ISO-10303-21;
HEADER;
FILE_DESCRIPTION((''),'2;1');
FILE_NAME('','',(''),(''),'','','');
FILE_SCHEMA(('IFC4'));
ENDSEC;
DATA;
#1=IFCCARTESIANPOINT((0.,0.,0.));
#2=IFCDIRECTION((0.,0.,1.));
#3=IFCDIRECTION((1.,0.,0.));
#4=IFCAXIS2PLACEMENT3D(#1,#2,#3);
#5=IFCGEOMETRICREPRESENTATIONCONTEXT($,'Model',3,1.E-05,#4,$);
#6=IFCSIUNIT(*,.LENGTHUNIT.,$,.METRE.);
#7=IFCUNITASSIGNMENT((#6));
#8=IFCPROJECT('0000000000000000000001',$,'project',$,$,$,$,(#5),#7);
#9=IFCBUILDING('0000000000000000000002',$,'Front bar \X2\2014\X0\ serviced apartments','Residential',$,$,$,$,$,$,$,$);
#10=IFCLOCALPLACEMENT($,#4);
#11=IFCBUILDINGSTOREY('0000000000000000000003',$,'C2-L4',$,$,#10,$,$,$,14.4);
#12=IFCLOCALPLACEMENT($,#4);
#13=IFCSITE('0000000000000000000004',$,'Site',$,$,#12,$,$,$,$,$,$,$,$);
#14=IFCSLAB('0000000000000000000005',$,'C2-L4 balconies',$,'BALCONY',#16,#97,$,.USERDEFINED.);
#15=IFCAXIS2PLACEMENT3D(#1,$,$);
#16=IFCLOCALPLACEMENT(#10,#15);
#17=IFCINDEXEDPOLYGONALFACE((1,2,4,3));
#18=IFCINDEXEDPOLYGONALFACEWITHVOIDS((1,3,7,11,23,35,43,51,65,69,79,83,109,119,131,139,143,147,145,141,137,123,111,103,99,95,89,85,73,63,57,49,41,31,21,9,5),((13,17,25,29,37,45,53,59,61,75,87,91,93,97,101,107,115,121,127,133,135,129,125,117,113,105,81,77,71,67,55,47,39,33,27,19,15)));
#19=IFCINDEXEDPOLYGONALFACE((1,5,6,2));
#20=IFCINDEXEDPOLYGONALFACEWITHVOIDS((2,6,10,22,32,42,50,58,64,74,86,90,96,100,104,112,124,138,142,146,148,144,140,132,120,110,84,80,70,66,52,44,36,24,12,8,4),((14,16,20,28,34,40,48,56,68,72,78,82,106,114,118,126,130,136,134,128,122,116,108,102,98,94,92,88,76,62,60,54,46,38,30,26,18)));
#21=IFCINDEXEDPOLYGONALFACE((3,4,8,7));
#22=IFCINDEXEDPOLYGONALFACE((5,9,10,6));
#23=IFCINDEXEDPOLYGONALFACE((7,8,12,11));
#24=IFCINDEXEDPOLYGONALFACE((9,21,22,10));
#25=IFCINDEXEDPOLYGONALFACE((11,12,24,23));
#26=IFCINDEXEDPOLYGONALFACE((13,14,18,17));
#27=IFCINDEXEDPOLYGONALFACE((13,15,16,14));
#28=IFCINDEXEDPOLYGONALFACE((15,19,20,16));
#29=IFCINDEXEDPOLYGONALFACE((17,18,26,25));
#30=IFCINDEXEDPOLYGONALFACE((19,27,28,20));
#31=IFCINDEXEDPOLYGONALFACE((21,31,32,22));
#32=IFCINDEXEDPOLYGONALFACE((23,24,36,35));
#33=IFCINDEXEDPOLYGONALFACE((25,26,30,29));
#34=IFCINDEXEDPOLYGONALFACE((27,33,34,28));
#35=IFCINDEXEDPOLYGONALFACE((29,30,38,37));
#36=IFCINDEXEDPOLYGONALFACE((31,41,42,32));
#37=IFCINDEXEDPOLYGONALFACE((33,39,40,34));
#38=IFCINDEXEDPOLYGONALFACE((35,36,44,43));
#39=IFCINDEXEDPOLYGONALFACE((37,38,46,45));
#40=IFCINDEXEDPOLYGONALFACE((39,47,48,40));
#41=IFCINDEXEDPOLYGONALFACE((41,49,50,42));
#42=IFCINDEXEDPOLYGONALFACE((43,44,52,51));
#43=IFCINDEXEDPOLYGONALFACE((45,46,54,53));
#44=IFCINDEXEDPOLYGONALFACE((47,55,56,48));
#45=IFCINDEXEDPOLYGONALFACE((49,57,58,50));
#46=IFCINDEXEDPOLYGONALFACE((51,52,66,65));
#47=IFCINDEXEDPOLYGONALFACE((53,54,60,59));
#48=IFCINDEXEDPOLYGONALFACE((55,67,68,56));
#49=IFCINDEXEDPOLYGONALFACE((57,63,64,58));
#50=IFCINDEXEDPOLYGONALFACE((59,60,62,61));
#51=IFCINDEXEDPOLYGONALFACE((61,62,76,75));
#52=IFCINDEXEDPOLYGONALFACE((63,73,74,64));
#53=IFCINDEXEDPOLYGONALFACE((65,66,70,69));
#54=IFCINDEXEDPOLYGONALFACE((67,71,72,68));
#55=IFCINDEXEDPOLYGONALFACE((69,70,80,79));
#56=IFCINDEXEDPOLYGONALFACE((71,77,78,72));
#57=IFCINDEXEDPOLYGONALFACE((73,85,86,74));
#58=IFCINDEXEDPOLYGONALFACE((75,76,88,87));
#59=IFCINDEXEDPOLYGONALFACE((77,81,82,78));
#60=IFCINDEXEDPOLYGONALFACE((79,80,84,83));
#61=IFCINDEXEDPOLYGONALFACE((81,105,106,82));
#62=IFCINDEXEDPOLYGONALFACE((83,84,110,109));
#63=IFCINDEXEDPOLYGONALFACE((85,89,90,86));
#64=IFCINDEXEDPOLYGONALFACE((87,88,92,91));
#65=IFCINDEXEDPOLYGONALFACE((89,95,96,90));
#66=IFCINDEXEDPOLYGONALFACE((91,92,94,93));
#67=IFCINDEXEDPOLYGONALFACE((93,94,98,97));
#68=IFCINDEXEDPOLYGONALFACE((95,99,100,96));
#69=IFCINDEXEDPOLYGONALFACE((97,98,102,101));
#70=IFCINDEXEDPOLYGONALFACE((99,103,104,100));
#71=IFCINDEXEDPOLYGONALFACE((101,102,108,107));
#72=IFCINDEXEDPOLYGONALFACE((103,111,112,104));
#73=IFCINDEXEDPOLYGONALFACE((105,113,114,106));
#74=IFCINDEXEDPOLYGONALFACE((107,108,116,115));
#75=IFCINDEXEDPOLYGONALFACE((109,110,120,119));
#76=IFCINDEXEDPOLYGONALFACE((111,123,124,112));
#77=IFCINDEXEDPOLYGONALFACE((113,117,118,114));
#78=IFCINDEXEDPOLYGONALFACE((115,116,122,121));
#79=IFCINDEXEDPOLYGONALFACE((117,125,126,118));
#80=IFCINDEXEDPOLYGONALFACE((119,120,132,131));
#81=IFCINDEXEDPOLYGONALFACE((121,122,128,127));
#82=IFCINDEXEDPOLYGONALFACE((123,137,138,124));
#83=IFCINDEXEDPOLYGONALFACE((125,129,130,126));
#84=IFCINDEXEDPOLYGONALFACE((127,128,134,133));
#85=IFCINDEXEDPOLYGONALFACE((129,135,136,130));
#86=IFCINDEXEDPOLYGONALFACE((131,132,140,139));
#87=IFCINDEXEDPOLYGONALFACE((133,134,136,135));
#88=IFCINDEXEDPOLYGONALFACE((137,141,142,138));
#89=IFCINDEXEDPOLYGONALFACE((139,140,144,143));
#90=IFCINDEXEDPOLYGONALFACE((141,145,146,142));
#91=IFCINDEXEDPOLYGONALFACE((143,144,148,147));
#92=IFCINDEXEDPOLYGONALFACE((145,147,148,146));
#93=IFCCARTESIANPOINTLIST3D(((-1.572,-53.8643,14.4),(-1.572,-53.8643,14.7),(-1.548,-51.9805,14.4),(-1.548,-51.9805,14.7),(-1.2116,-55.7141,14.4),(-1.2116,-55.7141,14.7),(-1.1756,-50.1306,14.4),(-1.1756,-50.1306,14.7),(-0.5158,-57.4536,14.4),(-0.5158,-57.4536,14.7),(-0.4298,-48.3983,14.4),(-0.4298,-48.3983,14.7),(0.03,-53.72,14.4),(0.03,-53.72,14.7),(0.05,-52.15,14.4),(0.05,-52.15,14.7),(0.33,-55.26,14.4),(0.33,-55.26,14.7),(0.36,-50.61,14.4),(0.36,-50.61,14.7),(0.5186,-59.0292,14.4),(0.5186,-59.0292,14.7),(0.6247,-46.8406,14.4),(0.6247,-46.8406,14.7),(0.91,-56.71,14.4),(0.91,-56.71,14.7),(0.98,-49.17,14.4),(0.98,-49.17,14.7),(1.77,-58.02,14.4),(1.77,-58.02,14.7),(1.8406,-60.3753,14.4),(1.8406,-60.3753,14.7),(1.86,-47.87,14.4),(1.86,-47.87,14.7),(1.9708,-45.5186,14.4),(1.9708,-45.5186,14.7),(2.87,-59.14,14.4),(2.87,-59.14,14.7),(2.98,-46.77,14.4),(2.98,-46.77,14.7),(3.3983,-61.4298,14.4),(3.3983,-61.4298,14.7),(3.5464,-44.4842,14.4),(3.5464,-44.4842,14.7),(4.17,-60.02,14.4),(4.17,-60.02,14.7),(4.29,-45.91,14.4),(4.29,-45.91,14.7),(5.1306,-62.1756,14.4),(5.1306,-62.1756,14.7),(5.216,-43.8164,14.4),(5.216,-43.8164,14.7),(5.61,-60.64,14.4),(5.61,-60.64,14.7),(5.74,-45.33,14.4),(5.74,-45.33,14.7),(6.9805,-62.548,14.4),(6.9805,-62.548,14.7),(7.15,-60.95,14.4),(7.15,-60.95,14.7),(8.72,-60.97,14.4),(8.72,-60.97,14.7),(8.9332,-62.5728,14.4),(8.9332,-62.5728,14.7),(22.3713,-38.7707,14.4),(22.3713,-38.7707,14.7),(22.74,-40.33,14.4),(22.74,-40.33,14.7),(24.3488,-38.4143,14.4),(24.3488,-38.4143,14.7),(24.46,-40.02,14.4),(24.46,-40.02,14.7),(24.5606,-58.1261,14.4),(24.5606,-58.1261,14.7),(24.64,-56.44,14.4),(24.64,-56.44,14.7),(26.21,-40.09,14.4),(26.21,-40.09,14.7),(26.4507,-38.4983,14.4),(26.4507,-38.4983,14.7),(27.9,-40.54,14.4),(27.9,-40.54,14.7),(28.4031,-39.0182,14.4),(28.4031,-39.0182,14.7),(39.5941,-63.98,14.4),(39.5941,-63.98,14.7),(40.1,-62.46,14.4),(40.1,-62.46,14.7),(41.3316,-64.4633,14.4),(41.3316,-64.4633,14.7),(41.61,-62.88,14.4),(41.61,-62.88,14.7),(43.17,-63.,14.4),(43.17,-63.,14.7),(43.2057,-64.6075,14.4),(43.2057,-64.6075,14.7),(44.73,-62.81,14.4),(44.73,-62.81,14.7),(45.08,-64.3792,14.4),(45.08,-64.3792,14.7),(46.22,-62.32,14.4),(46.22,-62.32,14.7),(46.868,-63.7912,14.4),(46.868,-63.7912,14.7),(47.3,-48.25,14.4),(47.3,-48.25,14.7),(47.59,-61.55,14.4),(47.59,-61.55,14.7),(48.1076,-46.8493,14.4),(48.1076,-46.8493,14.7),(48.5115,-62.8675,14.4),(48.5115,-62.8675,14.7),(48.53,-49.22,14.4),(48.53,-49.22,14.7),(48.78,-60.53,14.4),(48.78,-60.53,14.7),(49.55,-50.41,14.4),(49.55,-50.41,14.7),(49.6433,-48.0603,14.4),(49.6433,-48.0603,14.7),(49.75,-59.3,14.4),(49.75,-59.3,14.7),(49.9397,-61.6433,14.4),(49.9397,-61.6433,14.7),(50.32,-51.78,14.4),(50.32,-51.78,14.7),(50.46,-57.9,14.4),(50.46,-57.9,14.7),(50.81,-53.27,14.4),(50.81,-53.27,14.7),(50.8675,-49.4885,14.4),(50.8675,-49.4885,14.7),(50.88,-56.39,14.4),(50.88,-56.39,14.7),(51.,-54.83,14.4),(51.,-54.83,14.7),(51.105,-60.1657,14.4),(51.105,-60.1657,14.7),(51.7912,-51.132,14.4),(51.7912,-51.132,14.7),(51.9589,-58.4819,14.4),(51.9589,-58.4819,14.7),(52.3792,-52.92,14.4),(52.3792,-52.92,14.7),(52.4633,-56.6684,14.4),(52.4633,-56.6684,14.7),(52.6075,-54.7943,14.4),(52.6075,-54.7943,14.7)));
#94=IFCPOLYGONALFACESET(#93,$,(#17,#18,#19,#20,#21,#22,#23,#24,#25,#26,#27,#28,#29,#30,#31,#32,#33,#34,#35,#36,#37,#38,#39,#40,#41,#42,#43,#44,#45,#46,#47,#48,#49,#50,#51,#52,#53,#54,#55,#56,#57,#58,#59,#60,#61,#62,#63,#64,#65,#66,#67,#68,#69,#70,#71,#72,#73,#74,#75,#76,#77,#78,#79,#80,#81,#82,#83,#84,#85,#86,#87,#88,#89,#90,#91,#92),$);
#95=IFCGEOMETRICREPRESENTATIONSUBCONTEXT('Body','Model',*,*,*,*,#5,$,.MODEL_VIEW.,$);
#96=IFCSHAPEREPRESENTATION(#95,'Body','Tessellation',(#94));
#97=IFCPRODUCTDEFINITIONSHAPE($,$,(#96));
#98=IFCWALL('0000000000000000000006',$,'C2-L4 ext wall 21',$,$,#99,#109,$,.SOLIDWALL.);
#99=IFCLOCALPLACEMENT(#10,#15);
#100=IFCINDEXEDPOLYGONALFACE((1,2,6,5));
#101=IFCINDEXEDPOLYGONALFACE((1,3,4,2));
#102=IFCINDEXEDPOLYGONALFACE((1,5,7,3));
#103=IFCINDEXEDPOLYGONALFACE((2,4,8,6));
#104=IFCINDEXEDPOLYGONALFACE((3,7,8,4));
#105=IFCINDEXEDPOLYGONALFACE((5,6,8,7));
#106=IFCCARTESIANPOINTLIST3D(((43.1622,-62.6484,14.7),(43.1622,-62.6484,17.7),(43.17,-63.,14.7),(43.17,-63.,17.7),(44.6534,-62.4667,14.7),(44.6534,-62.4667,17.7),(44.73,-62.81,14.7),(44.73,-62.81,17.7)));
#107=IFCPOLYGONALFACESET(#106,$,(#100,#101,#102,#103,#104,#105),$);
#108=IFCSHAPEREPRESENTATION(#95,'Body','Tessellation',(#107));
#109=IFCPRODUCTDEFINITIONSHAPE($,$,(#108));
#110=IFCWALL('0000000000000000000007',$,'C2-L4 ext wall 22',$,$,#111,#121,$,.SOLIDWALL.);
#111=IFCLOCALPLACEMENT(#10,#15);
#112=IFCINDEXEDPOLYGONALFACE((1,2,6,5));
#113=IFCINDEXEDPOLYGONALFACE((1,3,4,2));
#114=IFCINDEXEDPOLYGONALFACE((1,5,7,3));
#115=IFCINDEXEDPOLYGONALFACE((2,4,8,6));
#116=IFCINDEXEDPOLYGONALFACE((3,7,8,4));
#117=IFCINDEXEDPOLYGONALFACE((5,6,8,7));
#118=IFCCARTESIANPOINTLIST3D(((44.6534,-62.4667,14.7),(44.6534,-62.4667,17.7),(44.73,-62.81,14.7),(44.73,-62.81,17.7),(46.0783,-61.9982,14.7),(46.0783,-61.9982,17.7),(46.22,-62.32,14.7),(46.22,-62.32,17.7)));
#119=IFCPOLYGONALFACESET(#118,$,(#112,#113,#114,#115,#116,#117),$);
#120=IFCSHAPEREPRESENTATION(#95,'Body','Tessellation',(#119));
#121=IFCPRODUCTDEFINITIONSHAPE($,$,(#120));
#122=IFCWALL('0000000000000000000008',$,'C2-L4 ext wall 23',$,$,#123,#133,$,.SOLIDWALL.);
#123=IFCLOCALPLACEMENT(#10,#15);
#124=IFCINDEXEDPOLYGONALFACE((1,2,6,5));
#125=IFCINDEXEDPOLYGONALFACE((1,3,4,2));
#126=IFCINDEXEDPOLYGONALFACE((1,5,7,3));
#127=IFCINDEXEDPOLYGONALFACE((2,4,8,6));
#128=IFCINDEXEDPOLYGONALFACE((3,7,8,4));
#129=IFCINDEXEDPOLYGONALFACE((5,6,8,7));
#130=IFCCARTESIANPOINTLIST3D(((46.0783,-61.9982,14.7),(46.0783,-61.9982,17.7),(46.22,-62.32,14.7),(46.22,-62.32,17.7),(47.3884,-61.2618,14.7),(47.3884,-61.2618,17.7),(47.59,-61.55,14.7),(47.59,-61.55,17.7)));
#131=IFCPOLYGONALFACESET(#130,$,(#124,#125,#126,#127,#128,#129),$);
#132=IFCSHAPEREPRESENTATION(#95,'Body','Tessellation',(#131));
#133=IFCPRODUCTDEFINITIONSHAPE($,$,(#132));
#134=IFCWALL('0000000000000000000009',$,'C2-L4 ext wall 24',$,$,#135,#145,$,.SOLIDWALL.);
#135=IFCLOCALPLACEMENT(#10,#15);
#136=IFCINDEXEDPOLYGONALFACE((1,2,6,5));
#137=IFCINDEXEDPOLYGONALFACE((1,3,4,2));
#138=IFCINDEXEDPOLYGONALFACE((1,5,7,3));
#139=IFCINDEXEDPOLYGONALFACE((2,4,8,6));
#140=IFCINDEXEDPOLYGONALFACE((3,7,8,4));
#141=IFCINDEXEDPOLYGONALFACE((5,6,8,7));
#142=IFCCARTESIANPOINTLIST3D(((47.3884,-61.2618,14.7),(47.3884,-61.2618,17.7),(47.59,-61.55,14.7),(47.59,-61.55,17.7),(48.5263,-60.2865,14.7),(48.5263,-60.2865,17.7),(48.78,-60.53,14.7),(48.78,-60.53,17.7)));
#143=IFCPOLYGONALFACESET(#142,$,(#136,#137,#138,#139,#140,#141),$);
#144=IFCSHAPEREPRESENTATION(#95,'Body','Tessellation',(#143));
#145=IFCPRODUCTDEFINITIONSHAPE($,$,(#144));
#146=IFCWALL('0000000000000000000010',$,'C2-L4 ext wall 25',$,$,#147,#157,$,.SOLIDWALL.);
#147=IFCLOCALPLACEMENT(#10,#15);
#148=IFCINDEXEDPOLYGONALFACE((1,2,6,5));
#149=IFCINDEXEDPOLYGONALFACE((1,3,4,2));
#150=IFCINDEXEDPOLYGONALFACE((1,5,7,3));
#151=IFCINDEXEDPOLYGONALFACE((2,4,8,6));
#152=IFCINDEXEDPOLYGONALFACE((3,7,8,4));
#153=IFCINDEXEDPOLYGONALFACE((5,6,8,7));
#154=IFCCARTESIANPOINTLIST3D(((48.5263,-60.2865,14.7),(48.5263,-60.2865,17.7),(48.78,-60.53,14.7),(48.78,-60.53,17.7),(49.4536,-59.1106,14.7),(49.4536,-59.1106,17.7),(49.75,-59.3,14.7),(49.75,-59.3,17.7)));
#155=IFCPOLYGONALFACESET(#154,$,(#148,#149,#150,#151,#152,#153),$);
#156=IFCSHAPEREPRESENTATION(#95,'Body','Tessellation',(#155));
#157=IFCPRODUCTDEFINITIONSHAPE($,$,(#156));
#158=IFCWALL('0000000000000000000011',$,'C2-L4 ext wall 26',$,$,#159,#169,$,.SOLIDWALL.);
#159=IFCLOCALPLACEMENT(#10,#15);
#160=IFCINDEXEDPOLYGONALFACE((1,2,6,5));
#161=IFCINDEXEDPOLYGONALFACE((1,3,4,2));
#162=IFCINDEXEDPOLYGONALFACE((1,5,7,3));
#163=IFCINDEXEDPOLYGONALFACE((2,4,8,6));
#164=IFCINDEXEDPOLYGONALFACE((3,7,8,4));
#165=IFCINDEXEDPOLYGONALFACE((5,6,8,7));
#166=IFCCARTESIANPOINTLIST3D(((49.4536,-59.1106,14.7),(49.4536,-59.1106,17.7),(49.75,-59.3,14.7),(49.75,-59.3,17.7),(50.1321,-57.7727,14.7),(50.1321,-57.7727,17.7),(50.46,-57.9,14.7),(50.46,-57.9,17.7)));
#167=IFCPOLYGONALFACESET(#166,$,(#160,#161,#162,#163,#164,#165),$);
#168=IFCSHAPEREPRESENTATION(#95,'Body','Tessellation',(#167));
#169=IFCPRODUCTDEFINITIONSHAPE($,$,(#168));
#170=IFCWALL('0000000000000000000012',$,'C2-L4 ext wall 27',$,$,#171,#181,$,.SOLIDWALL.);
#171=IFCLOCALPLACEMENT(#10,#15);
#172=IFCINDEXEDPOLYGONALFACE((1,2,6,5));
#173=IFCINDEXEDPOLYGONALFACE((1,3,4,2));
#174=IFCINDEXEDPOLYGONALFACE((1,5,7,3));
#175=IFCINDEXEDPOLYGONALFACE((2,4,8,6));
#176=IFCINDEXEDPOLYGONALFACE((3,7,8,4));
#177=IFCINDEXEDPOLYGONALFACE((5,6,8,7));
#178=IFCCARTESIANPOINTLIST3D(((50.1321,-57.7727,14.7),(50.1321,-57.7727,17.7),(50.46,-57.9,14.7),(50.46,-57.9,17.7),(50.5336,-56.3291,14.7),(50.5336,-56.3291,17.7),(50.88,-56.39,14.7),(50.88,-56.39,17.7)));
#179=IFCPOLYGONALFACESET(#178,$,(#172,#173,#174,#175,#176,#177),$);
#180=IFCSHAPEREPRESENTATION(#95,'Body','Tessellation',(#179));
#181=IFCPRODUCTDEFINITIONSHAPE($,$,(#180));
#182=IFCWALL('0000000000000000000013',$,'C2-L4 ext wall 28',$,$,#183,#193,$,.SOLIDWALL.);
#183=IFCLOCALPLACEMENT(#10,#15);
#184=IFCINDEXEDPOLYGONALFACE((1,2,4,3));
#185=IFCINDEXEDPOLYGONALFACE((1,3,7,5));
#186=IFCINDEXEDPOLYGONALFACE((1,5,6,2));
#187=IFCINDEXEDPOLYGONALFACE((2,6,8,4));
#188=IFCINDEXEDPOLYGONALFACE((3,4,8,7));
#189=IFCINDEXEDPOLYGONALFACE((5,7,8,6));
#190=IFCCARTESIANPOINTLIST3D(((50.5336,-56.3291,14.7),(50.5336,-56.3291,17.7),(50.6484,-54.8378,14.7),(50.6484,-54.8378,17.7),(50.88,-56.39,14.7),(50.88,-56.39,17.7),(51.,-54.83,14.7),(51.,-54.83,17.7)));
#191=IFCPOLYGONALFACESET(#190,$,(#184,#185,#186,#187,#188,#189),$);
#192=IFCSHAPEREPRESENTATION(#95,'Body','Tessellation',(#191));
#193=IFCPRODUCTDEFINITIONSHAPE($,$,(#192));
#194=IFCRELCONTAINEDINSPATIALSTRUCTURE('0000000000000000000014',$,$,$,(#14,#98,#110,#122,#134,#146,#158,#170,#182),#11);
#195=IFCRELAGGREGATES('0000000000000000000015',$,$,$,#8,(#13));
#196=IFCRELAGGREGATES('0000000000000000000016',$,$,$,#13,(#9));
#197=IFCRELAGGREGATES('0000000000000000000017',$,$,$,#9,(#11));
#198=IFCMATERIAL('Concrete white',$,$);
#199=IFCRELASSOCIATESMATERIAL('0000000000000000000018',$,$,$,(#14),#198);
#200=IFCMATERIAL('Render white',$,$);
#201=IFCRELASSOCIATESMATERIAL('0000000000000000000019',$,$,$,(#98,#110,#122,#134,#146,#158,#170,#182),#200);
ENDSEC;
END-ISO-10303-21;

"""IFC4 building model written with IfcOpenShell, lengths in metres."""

from ifc_helpers import new_model, si_unit, frame, origin_with_axes, place, context, subcontext, project, spatial, polyline, outline, extrude, material, element, save


model = new_model("IFC4")

# Units and contexts
model_context = context("Model", 3, precision=1e-05, world=origin_with_axes())
body_context = subcontext(model_context, "Body", "Model", "MODEL_VIEW")
ifc_project = project(units=[si_unit("LENGTHUNIT", "METRE")], contexts=[model_context])

# Site, building, storey
site_placement = place(None, origin_with_axes())
site = spatial("IfcSite", under=ifc_project, at=site_placement, Name="Site")
building = spatial("IfcBuilding", under=site, Name="Front bar — serviced apartments", Description="Residential")
storey_placement = place(None, origin_with_axes())
storey = spatial("IfcBuildingStorey", under=building, at=storey_placement, Name="C2-L4", Elevation=14.4)

# Slab
ifc_material_1 = material(Name="Concrete white")
slab_placement = place(storey_placement, origin_with_axes())
element("IfcSlab", 1, at=slab_placement, inside=storey, material=ifc_material_1, Name="C2-L4 balconies", ObjectType="BALCONY", PredefinedType="USERDEFINED", context=body_context, shape_type="SweptSolid", body=[
    extrude(outline(polyline([(22.3713, -38.7707), (5.216, -43.8164), (3.5464, -44.4842), (1.9708, -45.5186), (0.6247, -46.8406), (-0.4298, -48.3983), (-1.1756, -50.1306), (-1.548, -51.9805), (-1.572, -53.8643), (-1.2116, -55.7141), (-0.5158, -57.4536), (0.5186, -59.0292), (1.8406, -60.3753), (3.3983, -61.4298), (5.1306, -62.1756), (6.9805, -62.548), (8.9332, -62.5728), (24.5606, -58.1261), (39.5941, -63.98), (41.3316, -64.4633), (43.2057, -64.6075), (45.08, -64.3792), (46.868, -63.7912), (48.5115, -62.8675), (49.9397, -61.6433), (51.105, -60.1657), (51.9589, -58.4819), (52.4633, -56.6684), (52.6075, -54.7943), (52.3792, -52.92), (51.7912, -51.132), (50.8675, -49.4885), (49.6433, -48.0603), (48.1076, -46.8493), (28.4031, -39.0182), (26.4507, -38.4983), (24.3488, -38.4143), (22.3713, -38.7707)]), holes=[polyline([(22.74, -40.33), (5.74, -45.33), (4.29, -45.91), (2.98, -46.77), (1.86, -47.87), (0.98, -49.17), (0.36, -50.61), (0.05, -52.15), (0.03, -53.72), (0.33, -55.26), (0.91, -56.71), (1.77, -58.02), (2.87, -59.14), (4.17, -60.02), (5.61, -60.64), (7.15, -60.95), (8.72, -60.97), (24.64, -56.44), (40.1, -62.46), (41.61, -62.88), (43.17, -63.0), (44.73, -62.81), (46.22, -62.32), (47.59, -61.55), (48.78, -60.53), (49.75, -59.3), (50.46, -57.9), (50.88, -56.39), (51.0, -54.83), (50.81, -53.27), (50.32, -51.78), (49.55, -50.41), (48.53, -49.22), (47.3, -48.25), (27.9, -40.54), (26.21, -40.09), (24.46, -40.02), (22.74, -40.33)])]), frame((0.0, 0.0, 14.4), z_axis=(0.0, 0.0, 1.0), x_axis=(1.0, 0.0, 0.0)), (0.0, 0.0, 1.0), 0.3),
])

# Walls
ifc_material_2 = material(Name="Render white")
wall_1_placement = place(storey_placement, origin_with_axes())
element("IfcWall", 2, at=wall_1_placement, inside=storey, material=ifc_material_2, Name="C2-L4 ext wall 21", PredefinedType="SOLIDWALL", context=body_context, shape_type="SweptSolid", body=[
    extrude(outline(polyline([(43.17, -63.0), (44.73, -62.81), (44.6534, -62.4667), (43.1622, -62.6484), (43.17, -63.0)])), frame((0.0, 0.0, 14.7), z_axis=(0.0, 0.0, 1.0), x_axis=(1.0, 0.0, 0.0)), (0.0, 0.0, 1.0), 3.0),
])
wall_2_placement = place(storey_placement, origin_with_axes())
element("IfcWall", 3, at=wall_2_placement, inside=storey, material=ifc_material_2, Name="C2-L4 ext wall 22", PredefinedType="SOLIDWALL", context=body_context, shape_type="SweptSolid", body=[
    extrude(outline(polyline([(44.73, -62.81), (46.22, -62.32), (46.0783, -61.9982), (44.6534, -62.4667), (44.73, -62.81)])), frame((0.0, 0.0, 14.7), z_axis=(0.0, 0.0, 1.0), x_axis=(1.0, 0.0, 0.0)), (0.0, 0.0, 1.0), 3.0),
])
wall_3_placement = place(storey_placement, origin_with_axes())
element("IfcWall", 4, at=wall_3_placement, inside=storey, material=ifc_material_2, Name="C2-L4 ext wall 23", PredefinedType="SOLIDWALL", context=body_context, shape_type="SweptSolid", body=[
    extrude(outline(polyline([(46.22, -62.32), (47.59, -61.55), (47.3884, -61.2618), (46.0783, -61.9982), (46.22, -62.32)])), frame((0.0, 0.0, 14.7), z_axis=(0.0, 0.0, 1.0), x_axis=(1.0, 0.0, 0.0)), (0.0, 0.0, 1.0), 3.0),
])
wall_4_placement = place(storey_placement, origin_with_axes())
element("IfcWall", 5, at=wall_4_placement, inside=storey, material=ifc_material_2, Name="C2-L4 ext wall 24", PredefinedType="SOLIDWALL", context=body_context, shape_type="SweptSolid", body=[
    extrude(outline(polyline([(47.59, -61.55), (48.78, -60.53), (48.5263, -60.2865), (47.3884, -61.2618), (47.59, -61.55)])), frame((0.0, 0.0, 14.7), z_axis=(0.0, 0.0, 1.0), x_axis=(1.0, 0.0, 0.0)), (0.0, 0.0, 1.0), 3.0),
])
wall_5_placement = place(storey_placement, origin_with_axes())
element("IfcWall", 6, at=wall_5_placement, inside=storey, material=ifc_material_2, Name="C2-L4 ext wall 25", PredefinedType="SOLIDWALL", context=body_context, shape_type="SweptSolid", body=[
    extrude(outline(polyline([(48.78, -60.53), (49.75, -59.3), (49.4536, -59.1106), (48.5263, -60.2865), (48.78, -60.53)])), frame((0.0, 0.0, 14.7), z_axis=(0.0, 0.0, 1.0), x_axis=(1.0, 0.0, 0.0)), (0.0, 0.0, 1.0), 3.0),
])
wall_6_placement = place(storey_placement, origin_with_axes())
element("IfcWall", 7, at=wall_6_placement, inside=storey, material=ifc_material_2, Name="C2-L4 ext wall 26", PredefinedType="SOLIDWALL", context=body_context, shape_type="SweptSolid", body=[
    extrude(outline(polyline([(49.75, -59.3), (50.46, -57.9), (50.1321, -57.7727), (49.4536, -59.1106), (49.75, -59.3)])), frame((0.0, 0.0, 14.7), z_axis=(0.0, 0.0, 1.0), x_axis=(1.0, 0.0, 0.0)), (0.0, 0.0, 1.0), 3.0),
])
wall_7_placement = place(storey_placement, origin_with_axes())
element("IfcWall", 8, at=wall_7_placement, inside=storey, material=ifc_material_2, Name="C2-L4 ext wall 27", PredefinedType="SOLIDWALL", context=body_context, shape_type="SweptSolid", body=[
    extrude(outline(polyline([(50.46, -57.9), (50.88, -56.39), (50.5336, -56.3291), (50.1321, -57.7727), (50.46, -57.9)])), frame((0.0, 0.0, 14.7), z_axis=(0.0, 0.0, 1.0), x_axis=(1.0, 0.0, 0.0)), (0.0, 0.0, 1.0), 3.0),
])
wall_8_placement = place(storey_placement, origin_with_axes())
element("IfcWall", 9, at=wall_8_placement, inside=storey, material=ifc_material_2, Name="C2-L4 ext wall 28", PredefinedType="SOLIDWALL", context=body_context, shape_type="SweptSolid", body=[
    extrude(outline(polyline([(50.88, -56.39), (51.0, -54.83), (50.6484, -54.8378), (50.5336, -56.3291), (50.88, -56.39)])), frame((0.0, 0.0, 14.7), z_axis=(0.0, 0.0, 1.0), x_axis=(1.0, 0.0, 0.0)), (0.0, 0.0, 1.0), 3.0),
])

save(model, "model.ifc")
